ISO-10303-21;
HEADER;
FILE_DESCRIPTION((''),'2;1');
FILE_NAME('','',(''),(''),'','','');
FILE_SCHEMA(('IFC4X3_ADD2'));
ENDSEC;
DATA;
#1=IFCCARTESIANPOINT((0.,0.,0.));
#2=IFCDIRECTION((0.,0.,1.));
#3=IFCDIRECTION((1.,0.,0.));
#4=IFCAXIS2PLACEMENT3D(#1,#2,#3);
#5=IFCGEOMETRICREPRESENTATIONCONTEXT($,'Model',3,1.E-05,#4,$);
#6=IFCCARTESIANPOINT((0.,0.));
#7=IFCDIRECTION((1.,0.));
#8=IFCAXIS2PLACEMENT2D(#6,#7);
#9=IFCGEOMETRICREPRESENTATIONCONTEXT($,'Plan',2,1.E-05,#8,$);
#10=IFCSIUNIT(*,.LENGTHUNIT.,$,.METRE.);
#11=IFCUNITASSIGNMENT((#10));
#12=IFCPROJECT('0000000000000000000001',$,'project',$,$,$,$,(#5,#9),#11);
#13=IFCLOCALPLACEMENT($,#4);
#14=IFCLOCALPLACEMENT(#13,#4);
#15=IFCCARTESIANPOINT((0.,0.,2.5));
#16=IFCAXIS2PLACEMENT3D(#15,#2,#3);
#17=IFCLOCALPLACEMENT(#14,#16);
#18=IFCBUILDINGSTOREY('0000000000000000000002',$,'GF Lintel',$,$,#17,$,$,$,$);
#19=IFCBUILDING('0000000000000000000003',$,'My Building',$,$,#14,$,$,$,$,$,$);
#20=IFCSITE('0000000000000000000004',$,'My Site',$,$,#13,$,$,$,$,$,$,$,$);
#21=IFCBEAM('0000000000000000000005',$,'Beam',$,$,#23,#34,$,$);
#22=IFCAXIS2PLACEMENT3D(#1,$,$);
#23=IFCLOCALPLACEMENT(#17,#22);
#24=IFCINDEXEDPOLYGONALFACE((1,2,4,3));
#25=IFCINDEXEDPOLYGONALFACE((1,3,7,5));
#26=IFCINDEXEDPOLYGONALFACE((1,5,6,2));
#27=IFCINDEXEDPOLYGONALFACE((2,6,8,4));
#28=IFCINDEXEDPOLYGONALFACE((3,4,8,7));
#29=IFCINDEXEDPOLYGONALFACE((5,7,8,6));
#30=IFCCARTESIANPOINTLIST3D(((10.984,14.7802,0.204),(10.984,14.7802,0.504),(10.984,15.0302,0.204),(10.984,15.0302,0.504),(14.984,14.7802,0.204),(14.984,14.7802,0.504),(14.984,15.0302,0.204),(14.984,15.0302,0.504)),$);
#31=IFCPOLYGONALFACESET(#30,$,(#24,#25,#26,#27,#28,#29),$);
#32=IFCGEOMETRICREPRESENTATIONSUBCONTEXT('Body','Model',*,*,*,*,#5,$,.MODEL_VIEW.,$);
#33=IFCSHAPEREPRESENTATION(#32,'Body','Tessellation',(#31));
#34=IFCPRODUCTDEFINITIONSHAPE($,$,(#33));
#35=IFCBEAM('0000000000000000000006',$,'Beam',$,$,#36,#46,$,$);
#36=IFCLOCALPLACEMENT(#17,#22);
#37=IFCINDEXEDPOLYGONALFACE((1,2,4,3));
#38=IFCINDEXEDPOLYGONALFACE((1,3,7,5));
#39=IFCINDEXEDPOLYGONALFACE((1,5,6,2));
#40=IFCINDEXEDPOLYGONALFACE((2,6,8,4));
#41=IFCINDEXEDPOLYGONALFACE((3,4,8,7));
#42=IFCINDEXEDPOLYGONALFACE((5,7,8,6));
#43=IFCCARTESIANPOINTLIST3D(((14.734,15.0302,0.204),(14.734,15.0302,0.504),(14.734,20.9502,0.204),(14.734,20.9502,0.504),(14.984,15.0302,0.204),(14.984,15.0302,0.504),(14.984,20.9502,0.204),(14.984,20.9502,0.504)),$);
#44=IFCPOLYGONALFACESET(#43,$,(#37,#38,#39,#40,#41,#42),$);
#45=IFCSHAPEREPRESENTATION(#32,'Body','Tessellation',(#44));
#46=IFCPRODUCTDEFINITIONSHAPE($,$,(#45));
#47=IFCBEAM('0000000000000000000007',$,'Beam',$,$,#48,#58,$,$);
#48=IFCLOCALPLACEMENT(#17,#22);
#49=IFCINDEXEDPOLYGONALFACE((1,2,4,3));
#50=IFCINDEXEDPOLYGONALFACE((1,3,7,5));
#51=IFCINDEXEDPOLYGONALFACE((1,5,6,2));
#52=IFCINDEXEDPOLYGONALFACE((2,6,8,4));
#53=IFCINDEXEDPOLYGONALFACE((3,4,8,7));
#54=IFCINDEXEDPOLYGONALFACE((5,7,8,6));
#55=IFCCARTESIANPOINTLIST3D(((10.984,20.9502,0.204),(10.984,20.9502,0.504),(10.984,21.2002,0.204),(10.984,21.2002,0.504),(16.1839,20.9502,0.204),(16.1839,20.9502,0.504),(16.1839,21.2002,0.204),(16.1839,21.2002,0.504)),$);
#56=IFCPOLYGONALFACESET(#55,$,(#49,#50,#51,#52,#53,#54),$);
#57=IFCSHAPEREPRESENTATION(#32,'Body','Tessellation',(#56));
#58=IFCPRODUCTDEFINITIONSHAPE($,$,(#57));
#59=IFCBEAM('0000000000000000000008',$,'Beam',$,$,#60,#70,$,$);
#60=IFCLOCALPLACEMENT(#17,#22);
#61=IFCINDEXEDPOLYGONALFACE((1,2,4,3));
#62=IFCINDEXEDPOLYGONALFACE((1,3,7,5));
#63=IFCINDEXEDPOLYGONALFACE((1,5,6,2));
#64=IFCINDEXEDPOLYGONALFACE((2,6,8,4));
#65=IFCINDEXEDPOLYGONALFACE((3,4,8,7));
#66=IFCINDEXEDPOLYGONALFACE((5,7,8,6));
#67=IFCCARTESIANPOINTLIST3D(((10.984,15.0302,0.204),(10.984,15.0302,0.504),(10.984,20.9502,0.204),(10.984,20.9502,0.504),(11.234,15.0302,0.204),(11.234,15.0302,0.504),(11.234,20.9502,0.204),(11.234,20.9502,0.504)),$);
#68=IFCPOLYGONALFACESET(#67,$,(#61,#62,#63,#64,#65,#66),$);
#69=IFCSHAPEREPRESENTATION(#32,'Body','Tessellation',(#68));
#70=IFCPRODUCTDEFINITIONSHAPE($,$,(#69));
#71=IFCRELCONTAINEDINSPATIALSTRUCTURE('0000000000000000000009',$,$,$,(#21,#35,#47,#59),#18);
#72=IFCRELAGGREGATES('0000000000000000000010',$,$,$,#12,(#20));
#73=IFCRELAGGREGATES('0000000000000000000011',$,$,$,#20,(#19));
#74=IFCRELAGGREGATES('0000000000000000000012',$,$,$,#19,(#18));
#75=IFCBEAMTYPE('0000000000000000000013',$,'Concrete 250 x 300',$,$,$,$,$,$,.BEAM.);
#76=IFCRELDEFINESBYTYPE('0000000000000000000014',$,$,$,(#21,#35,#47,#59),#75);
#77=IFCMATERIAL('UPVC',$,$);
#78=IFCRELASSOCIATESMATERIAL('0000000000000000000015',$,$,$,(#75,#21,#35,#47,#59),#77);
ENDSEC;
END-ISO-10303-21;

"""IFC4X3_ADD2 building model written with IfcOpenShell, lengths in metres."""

from ifc_helpers import new_model, si_unit, frame, origin_with_axes, origin_2d_with_axis, place, context, subcontext, project, spatial, rectangle, extrude, material, material_profile, profile_set, profile_usage, type_object, element, save


model = new_model("IFC4X3_ADD2")

# Units and contexts
model_context = context("Model", 3, precision=1e-05, world=origin_with_axes())
plan_context = context("Plan", 2, precision=1e-05, world=origin_2d_with_axis())
body_context = subcontext(model_context, "Body", "Model", "MODEL_VIEW")
ifc_project = project(units=[si_unit("LENGTHUNIT", "METRE")], contexts=[model_context, plan_context])

# Site, building, storey
site_placement = place(None, origin_with_axes())
site = spatial("IfcSite", under=ifc_project, at=site_placement, Name="My Site")
building_placement = place(site_placement, origin_with_axes())
building = spatial("IfcBuilding", under=site, at=building_placement, Name="My Building")
storey_placement = place(building_placement, frame((0.0, 0.0, 2.5), z_axis=(0.0, 0.0, 1.0), x_axis=(1.0, 0.0, 0.0)))
storey = spatial("IfcBuildingStorey", under=building, at=storey_placement, Name="GF Lintel")

# Beams
ifc_material_1 = material(Name="UPVC")
ifc_material_profile = material_profile(ifc_material_1, rectangle(XDim=0.25, YDim=0.3))
ifc_profile_set = profile_set([ifc_material_profile])
ifc_profile_usage_1 = profile_usage(ifc_profile_set, cardinal=5)
beam_type = type_object("IfcBeamType", Name="Concrete 250 x 300", PredefinedType="BEAM", material=ifc_profile_set)
beam_1_placement = place(storey_placement, frame((10.984, 14.9052, 0.354), z_axis=(1.0, 0.0, 0.0), x_axis=(0.0, 1.0, 0.0)))
element("IfcBeam", 1, at=beam_1_placement, inside=storey, type_object=beam_type, material=ifc_profile_usage_1, Name="Beam", context=body_context, shape_type="SweptSolid", body=[
    extrude(rectangle(XDim=0.25, YDim=0.3), origin_with_axes(), (0.0, 0.0, 1.0), 4.0),
])
ifc_profile_usage_2 = profile_usage(ifc_profile_set, cardinal=5)
beam_2_placement = place(storey_placement, frame((14.859, 15.0302, 0.354), z_axis=(0.0, 1.0, 0.0), x_axis=(-1.0, 0.0, 0.0)))
element("IfcBeam", 2, at=beam_2_placement, inside=storey, type_object=beam_type, material=ifc_profile_usage_2, Name="Beam", context=body_context, shape_type="SweptSolid", body=[
    extrude(rectangle(XDim=0.25, YDim=0.3), origin_with_axes(), (0.0, 0.0, 1.0), 5.92),
])
ifc_profile_usage_3 = profile_usage(ifc_profile_set, cardinal=5)
beam_3_placement = place(storey_placement, frame((10.984, 21.0752, 0.354), z_axis=(1.0, 0.0, 0.0), x_axis=(0.0, 1.0, 0.0)))
element("IfcBeam", 3, at=beam_3_placement, inside=storey, type_object=beam_type, material=ifc_profile_usage_3, Name="Beam", context=body_context, shape_type="SweptSolid", body=[
    extrude(rectangle(XDim=0.25, YDim=0.3), origin_with_axes(), (0.0, 0.0, 1.0), 5.2),
])
ifc_profile_usage_4 = profile_usage(ifc_profile_set, cardinal=5)
beam_4_placement = place(storey_placement, frame((11.109, 15.0302, 0.354), z_axis=(0.0, 1.0, 0.0), x_axis=(-1.0, 0.0, 0.0)))
element("IfcBeam", 4, at=beam_4_placement, inside=storey, type_object=beam_type, material=ifc_profile_usage_4, Name="Beam", context=body_context, shape_type="SweptSolid", body=[
    extrude(rectangle(XDim=0.25, YDim=0.3), origin_with_axes(), (0.0, 0.0, 1.0), 5.92),
])

save(model, "model.ifc")
